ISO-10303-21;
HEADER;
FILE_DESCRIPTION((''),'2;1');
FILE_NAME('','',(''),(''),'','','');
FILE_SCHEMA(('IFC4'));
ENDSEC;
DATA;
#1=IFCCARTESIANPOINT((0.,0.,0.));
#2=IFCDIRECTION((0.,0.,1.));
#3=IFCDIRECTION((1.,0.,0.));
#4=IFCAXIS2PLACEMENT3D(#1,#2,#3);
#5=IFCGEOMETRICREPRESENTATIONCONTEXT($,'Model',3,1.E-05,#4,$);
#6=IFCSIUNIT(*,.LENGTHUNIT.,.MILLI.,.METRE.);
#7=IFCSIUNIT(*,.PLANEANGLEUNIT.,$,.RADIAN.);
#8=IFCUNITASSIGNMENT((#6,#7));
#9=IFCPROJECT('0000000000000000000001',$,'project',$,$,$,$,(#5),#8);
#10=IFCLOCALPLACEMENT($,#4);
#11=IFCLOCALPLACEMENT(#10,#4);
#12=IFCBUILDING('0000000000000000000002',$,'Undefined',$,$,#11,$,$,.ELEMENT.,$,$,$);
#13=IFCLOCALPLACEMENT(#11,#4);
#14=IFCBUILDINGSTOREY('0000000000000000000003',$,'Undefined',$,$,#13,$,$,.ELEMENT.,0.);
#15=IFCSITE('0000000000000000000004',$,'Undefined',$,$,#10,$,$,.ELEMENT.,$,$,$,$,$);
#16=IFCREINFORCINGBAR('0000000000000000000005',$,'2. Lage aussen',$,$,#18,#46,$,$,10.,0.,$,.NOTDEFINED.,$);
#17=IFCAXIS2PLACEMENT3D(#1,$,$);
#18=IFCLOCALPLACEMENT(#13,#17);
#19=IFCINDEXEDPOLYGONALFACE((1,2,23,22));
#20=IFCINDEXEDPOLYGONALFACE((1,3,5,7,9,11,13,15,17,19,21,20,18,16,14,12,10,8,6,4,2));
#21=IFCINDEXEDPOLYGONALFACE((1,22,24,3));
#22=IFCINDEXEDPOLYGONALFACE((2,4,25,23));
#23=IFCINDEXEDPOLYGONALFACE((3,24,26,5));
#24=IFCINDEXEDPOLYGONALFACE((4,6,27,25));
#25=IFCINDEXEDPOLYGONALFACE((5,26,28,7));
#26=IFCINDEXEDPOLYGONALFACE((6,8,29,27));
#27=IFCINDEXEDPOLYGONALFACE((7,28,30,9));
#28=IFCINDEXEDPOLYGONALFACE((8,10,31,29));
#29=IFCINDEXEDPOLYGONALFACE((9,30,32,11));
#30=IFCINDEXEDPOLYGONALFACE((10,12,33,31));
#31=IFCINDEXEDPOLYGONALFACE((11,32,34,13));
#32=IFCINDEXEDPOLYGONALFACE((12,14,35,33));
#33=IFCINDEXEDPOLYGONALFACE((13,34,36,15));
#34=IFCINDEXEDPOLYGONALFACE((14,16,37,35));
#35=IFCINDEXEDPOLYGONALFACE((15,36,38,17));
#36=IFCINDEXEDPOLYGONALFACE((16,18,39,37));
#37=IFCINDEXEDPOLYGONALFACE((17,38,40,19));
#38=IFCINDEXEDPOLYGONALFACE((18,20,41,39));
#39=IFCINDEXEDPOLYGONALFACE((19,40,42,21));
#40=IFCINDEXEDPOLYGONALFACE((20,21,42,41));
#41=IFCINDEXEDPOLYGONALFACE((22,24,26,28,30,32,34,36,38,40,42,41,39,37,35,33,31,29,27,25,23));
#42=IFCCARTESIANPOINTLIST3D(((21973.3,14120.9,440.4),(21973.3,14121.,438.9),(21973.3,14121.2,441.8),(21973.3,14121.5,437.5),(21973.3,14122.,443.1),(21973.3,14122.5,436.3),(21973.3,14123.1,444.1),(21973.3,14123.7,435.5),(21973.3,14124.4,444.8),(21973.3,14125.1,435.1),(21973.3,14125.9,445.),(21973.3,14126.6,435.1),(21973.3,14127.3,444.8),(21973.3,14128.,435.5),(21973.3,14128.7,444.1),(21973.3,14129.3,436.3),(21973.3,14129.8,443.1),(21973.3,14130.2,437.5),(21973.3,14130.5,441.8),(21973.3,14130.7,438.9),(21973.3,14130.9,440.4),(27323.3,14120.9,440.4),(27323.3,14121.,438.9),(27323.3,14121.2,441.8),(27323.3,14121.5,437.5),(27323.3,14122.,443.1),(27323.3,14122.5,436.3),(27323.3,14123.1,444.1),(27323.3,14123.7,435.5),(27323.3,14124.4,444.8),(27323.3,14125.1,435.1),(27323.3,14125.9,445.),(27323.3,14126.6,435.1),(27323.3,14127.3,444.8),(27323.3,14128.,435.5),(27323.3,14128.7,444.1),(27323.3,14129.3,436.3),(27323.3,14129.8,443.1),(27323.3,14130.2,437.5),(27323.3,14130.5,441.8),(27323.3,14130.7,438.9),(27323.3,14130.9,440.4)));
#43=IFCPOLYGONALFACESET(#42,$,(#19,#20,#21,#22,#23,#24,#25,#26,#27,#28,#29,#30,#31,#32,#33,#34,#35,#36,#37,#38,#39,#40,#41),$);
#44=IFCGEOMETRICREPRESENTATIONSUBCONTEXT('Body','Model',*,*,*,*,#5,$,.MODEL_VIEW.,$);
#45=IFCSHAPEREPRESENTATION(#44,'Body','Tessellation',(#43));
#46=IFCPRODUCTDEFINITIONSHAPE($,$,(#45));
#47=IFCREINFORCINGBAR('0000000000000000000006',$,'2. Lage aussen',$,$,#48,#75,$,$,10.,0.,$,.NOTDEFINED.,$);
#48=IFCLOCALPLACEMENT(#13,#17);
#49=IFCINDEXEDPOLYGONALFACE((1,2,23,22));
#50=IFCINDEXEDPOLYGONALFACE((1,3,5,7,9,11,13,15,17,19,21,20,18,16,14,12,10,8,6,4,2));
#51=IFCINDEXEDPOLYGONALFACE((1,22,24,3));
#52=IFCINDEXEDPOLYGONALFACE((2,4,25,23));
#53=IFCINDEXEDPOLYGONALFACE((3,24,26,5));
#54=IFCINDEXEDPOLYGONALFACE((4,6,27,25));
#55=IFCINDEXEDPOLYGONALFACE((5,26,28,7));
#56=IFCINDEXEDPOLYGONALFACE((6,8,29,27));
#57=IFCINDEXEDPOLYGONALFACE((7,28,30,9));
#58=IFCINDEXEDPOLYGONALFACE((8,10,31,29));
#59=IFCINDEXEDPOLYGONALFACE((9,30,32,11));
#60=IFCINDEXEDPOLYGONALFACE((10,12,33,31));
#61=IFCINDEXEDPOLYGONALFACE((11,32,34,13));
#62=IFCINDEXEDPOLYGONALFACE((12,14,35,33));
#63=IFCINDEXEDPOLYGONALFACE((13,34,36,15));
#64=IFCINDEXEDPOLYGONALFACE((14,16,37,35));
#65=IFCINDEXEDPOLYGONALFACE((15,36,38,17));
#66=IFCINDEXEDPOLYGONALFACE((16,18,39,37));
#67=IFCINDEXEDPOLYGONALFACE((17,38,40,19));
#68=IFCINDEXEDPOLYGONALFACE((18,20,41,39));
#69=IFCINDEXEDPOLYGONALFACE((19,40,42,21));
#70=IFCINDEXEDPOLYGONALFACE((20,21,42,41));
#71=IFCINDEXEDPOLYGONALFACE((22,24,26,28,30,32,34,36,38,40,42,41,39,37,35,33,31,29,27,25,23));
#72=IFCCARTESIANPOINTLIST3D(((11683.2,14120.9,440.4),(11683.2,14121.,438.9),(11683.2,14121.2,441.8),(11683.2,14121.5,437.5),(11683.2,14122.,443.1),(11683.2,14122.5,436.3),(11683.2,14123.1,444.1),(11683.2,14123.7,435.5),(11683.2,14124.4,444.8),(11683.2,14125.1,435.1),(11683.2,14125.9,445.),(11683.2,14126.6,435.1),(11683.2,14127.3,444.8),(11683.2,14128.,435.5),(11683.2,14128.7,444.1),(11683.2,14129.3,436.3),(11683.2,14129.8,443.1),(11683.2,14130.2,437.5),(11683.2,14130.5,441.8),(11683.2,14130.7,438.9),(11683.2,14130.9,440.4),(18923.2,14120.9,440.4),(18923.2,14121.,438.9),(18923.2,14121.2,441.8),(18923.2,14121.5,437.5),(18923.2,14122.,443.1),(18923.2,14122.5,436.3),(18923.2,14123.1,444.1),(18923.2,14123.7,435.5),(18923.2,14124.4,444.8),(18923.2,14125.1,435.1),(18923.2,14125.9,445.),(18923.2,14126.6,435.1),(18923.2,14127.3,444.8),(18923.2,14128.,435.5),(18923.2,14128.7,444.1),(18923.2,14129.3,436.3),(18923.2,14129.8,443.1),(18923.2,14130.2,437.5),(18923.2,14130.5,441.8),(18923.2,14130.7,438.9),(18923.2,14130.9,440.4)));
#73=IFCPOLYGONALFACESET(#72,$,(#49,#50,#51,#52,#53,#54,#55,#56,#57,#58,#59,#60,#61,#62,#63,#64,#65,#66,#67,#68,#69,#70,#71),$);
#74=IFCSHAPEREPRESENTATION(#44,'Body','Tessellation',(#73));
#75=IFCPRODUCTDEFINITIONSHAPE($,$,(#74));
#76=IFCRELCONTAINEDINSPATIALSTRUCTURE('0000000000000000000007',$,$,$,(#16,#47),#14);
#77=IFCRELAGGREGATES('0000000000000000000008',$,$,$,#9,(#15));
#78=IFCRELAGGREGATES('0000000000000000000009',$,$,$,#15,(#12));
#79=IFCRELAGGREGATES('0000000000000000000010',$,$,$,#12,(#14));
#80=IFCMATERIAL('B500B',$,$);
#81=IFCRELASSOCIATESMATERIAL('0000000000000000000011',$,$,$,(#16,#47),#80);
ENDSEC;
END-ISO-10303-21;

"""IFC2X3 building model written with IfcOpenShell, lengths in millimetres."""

from ifc_helpers import new_model, entity, si_unit, frame, origin_with_axes, place, context, subcontext, project, spatial, source, transform, mapped, material, element, save


model = new_model("IFC2X3")

# Units and contexts
model_context = context("Model", 3, precision=1e-05, world=origin_with_axes())
body_context = subcontext(model_context, "Body", "Model", "MODEL_VIEW")
ifc_project = project(units=[si_unit("LENGTHUNIT", "METRE", prefix="MILLI"), si_unit("PLANEANGLEUNIT", "RADIAN")], contexts=[model_context])

# Site, building, storey
site_placement = place(None, origin_with_axes())
site = spatial("IfcSite", under=ifc_project, at=site_placement, Name="Undefined", CompositionType="ELEMENT")
building_placement = place(site_placement, origin_with_axes())
building = spatial("IfcBuilding", under=site, at=building_placement, Name="Undefined", CompositionType="ELEMENT")
storey_placement = place(building_placement, origin_with_axes())
storey = spatial("IfcBuildingStorey", under=building, at=storey_placement, Name="Undefined", CompositionType="ELEMENT", Elevation=0.0)

# Reinforcing bars
ifc_material_1 = material(Name="B500B")
shared_shape_1 = source(origin_with_axes(), body_context, "Body", "AdvancedSweptSolid", [
    entity("IfcSweptDiskSolid", entity("IfcTrimmedCurve", entity("IfcLine", entity("IfcCartesianPoint", [0.0, 0.0, 0.0]), entity("IfcVector", entity("IfcDirection", [1.0, 0.0, 0.0]), 1.0)), [entity("IfcParameterValue", 0.0)], [entity("IfcParameterValue", 5350.0)], True, "PARAMETER"), 5.0, None, 0.0, 5350.0),
])
reinforcing_bar_1_placement = place(storey_placement, frame((27323.3, 14125.9, 440.0), z_axis=(0.0, 0.0, 1.0), x_axis=(-1.0, 0.0, 0.0)))
element("IfcReinforcingBar", 1, at=reinforcing_bar_1_placement, inside=storey, material=ifc_material_1, Name="2. Lage aussen", BarRole="NOTDEFINED", CrossSectionArea=0.0, NominalDiameter=10.0, context=body_context, shape_type="MappedRepresentation", body=[
    mapped(shared_shape_1, transform((0.0, 0.0, 0.0))),
])
shared_shape_2 = source(origin_with_axes(), body_context, "Body", "AdvancedSweptSolid", [
    entity("IfcSweptDiskSolid", entity("IfcTrimmedCurve", entity("IfcLine", entity("IfcCartesianPoint", [0.0, 0.0, 0.0]), entity("IfcVector", entity("IfcDirection", [1.0, 0.0, 0.0]), 1.0)), [entity("IfcParameterValue", 0.0)], [entity("IfcParameterValue", 7240.0)], True, "PARAMETER"), 5.0, None, 0.0, 7240.0),
])
reinforcing_bar_2_placement = place(storey_placement, frame((18923.2, 14125.9, 440.0), z_axis=(0.0, 0.0, 1.0), x_axis=(-1.0, 0.0, 0.0)))
element("IfcReinforcingBar", 2, at=reinforcing_bar_2_placement, inside=storey, material=ifc_material_1, Name="2. Lage aussen", BarRole="NOTDEFINED", CrossSectionArea=0.0, NominalDiameter=10.0, context=body_context, shape_type="MappedRepresentation", body=[
    mapped(shared_shape_2, transform((0.0, 0.0, 0.0))),
])

save(model, "model.ifc")
